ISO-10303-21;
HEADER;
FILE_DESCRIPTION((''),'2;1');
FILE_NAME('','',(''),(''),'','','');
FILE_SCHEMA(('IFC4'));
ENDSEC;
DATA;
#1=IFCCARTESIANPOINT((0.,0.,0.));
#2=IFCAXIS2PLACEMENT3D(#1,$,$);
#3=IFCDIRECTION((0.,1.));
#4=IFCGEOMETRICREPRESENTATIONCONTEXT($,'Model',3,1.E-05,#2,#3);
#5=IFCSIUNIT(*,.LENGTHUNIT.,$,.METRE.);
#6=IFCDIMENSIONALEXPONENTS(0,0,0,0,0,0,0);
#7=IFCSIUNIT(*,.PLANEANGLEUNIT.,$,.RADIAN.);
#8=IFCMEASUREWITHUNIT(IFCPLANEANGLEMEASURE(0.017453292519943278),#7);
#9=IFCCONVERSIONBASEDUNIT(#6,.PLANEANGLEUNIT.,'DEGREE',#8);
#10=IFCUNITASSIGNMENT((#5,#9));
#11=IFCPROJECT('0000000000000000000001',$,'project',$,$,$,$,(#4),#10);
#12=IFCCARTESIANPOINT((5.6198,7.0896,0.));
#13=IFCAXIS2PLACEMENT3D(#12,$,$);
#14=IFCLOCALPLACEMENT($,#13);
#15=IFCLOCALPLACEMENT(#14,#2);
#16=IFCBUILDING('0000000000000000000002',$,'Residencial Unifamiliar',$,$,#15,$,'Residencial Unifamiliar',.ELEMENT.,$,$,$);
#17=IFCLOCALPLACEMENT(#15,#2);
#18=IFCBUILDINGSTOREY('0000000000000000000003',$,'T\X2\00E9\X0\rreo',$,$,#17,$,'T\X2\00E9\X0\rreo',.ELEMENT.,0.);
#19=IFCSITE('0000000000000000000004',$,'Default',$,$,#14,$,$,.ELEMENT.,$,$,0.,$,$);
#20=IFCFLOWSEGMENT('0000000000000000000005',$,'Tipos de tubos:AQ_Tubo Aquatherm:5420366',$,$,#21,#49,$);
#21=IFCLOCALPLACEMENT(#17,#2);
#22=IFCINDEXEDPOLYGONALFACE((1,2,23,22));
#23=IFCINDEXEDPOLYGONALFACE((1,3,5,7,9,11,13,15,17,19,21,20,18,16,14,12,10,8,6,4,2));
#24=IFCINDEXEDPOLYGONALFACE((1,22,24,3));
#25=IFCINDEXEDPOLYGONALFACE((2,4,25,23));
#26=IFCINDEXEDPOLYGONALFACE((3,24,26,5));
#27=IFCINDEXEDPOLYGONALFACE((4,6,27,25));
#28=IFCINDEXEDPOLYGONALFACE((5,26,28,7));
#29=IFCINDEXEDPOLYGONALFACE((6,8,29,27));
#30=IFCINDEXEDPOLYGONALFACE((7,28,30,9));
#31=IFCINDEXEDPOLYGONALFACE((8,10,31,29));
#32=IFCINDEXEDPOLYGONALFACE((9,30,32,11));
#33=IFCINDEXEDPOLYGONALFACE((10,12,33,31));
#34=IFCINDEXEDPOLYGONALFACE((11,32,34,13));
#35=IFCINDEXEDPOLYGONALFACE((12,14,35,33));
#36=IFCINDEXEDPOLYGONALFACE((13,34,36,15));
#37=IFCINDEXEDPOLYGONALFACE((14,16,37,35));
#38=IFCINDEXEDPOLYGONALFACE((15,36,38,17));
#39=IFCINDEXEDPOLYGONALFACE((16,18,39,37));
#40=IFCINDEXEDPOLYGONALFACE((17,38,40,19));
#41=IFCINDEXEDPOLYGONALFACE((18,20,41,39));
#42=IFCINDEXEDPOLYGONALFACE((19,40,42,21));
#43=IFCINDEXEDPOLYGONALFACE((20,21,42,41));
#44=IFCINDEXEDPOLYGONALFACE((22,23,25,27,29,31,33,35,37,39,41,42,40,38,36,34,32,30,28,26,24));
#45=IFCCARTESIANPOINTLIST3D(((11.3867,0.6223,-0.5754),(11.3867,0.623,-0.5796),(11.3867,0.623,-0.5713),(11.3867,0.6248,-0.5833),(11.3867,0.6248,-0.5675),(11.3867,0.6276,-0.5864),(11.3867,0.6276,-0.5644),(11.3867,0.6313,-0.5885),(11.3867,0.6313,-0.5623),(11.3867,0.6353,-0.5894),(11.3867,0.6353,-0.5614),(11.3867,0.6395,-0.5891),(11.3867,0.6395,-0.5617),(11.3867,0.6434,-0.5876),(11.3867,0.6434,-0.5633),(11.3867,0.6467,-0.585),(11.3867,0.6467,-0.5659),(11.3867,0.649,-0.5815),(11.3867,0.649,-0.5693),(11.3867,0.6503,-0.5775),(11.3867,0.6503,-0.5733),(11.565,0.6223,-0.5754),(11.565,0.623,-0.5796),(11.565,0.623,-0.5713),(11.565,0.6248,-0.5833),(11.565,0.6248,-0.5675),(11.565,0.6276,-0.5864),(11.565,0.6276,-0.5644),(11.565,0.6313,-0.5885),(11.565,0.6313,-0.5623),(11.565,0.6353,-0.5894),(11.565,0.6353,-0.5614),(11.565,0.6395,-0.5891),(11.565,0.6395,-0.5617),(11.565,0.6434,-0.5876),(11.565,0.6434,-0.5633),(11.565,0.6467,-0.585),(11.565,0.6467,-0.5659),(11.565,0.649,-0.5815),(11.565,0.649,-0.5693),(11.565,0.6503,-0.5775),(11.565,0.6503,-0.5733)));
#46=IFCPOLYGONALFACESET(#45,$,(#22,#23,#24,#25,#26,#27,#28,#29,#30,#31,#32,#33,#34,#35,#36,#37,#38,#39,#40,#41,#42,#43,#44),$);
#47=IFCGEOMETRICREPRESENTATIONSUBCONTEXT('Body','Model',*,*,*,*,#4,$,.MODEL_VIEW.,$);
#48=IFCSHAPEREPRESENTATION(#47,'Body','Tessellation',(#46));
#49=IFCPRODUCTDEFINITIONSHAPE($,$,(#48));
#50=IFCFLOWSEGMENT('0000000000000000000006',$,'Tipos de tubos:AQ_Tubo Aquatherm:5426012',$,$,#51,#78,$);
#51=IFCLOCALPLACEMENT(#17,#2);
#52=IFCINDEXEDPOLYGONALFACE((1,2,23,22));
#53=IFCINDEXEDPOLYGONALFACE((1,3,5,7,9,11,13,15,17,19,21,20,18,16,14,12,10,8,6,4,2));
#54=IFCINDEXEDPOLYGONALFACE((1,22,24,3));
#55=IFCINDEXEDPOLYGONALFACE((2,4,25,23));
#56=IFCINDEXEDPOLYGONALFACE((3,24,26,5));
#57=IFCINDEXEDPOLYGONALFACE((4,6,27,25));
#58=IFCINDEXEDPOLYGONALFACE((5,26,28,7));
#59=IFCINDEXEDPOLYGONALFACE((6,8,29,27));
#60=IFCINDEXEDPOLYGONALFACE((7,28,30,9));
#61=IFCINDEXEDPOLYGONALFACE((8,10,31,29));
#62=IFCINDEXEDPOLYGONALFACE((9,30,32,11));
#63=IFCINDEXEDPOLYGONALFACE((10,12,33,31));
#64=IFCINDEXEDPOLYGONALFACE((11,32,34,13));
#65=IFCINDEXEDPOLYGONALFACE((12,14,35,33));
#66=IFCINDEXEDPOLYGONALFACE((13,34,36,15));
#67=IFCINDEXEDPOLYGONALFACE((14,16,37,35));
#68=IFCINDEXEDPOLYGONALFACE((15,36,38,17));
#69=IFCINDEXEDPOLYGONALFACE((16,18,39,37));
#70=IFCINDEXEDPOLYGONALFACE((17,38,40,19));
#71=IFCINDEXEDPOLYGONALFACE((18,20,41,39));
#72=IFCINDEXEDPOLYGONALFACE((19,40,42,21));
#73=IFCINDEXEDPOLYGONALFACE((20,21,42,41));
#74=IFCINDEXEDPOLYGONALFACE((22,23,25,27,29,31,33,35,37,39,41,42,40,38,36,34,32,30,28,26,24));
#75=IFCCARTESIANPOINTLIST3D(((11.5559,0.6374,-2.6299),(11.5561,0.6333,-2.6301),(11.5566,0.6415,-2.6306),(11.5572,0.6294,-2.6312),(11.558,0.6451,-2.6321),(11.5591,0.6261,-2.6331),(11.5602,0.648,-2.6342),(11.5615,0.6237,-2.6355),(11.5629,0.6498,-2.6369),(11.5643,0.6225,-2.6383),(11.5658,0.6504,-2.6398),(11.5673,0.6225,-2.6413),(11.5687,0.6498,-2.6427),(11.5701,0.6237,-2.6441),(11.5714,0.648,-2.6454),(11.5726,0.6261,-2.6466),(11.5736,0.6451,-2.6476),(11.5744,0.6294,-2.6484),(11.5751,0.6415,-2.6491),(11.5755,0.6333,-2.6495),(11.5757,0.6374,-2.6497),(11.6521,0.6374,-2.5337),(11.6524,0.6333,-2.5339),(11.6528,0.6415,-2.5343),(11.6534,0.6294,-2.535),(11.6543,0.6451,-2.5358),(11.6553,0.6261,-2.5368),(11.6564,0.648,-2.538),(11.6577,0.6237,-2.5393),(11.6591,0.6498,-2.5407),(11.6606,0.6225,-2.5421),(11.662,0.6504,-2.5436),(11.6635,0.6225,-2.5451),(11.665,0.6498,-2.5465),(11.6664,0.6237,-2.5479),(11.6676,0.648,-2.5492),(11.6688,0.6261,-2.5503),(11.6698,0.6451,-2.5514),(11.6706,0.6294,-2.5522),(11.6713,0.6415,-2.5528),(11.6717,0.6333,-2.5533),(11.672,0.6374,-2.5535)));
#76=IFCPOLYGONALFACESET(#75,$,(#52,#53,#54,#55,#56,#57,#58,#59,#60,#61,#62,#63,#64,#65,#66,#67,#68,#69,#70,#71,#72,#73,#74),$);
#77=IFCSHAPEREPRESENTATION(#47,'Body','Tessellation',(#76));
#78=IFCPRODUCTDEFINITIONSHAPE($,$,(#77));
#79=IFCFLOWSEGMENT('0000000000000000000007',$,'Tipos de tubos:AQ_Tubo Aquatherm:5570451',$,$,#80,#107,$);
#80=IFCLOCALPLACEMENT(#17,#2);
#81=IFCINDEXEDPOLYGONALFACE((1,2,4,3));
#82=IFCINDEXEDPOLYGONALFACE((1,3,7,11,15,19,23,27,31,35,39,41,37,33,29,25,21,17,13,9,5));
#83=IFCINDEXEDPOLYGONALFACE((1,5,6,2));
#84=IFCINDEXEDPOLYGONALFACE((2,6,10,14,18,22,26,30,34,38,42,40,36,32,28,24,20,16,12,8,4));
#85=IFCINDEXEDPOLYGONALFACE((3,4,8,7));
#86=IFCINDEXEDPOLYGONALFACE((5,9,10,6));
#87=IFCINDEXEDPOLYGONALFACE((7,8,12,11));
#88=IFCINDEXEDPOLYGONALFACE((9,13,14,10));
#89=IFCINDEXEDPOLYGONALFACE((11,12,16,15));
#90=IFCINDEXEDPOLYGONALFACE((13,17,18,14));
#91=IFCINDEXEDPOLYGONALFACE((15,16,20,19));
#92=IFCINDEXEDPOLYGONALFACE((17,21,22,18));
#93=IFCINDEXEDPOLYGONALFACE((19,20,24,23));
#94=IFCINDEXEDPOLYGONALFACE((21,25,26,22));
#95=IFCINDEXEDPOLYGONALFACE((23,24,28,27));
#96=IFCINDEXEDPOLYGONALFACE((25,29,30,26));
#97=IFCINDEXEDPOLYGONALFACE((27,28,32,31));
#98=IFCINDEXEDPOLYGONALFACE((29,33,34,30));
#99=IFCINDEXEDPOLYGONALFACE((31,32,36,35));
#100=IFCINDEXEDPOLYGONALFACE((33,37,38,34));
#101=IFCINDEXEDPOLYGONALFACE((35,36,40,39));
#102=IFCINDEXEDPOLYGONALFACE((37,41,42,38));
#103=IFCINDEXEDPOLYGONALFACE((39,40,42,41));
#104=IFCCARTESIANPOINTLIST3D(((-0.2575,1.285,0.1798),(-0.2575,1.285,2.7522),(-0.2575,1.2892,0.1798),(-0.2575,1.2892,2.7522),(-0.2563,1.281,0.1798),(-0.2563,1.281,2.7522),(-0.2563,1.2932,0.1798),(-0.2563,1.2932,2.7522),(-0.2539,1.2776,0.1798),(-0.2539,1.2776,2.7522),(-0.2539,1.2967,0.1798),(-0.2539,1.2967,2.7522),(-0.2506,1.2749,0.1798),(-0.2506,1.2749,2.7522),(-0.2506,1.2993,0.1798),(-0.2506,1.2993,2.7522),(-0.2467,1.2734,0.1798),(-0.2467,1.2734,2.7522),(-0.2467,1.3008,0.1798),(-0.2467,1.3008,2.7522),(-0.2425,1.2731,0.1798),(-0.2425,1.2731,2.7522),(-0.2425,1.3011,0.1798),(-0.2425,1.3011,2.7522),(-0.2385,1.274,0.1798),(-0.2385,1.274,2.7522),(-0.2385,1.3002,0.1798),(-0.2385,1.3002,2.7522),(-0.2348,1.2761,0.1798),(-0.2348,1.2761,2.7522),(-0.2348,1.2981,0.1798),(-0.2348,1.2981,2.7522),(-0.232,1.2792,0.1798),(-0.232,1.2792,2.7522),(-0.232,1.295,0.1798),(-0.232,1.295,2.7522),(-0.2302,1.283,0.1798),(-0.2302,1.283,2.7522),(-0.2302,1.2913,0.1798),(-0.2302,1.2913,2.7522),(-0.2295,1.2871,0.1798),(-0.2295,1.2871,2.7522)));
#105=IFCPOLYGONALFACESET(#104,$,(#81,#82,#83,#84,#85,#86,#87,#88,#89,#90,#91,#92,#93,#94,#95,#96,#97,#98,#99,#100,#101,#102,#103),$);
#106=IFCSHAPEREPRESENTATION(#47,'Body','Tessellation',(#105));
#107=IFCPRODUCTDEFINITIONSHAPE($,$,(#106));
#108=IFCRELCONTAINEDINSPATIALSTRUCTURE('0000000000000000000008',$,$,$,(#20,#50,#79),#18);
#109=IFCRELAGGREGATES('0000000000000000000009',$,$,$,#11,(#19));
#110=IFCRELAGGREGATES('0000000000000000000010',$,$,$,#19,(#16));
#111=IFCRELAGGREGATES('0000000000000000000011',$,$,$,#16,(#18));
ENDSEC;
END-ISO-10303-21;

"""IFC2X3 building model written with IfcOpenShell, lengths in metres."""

from ifc_helpers import new_model, entity, si_unit, converted_unit, direction, frame, frame_2d, origin, origin_2d_with_axis, place, context, subcontext, project, spatial, circle, extrude, element, save


model = new_model("IFC2X3")

# Units and contexts
model_context = context("Model", 3, precision=1e-05, world=origin(), true_north=direction((0.0, 1.0)))
body_context = subcontext(model_context, "Body", "Model", "MODEL_VIEW")
ifc_project = project(units=[si_unit("LENGTHUNIT", "METRE"), converted_unit("PLANEANGLEUNIT", "DEGREE", entity("IfcPlaneAngleMeasure", 0.017453292519943278), si_unit("PLANEANGLEUNIT", "RADIAN"), dimensions=[0, 0, 0, 0, 0, 0, 0])], contexts=[model_context])

# Site, building, storey
site_placement = place(None, frame((5.6198, 7.0896, 0.0)))
site = spatial("IfcSite", under=ifc_project, at=site_placement, Name="Default", CompositionType="ELEMENT", RefElevation=0.0)
building_placement = place(site_placement, origin())
building = spatial("IfcBuilding", under=site, at=building_placement, Name="Residencial Unifamiliar", LongName="Residencial Unifamiliar", CompositionType="ELEMENT")
storey_placement = place(building_placement, origin())
storey = spatial("IfcBuildingStorey", under=building, at=storey_placement, Name="Térreo", LongName="Térreo", CompositionType="ELEMENT", Elevation=0.0)

# Flow segments
flow_segment_1_placement = place(storey_placement, origin())
element("IfcFlowSegment", 1, at=flow_segment_1_placement, inside=storey, Name="Tipos de tubos:AQ_Tubo Aquatherm:5420366", context=body_context, shape_type="SweptSolid", body=[
    extrude(circle(Radius=0.0141, at=origin_2d_with_axis()), frame((11.3867, 0.6364, -0.5754), z_axis=(1.0, 0.0, 0.0), x_axis=(0.0, -1.0, 0.0)), (0.0, 0.0, 1.0), 0.1783),
])
flow_segment_2_placement = place(storey_placement, origin())
element("IfcFlowSegment", 2, at=flow_segment_2_placement, inside=storey, Name="Tipos de tubos:AQ_Tubo Aquatherm:5426012", context=body_context, shape_type="SweptSolid", body=[
    extrude(circle(Radius=0.0141, at=frame_2d((0.0, 0.0), x_axis=(1.0, 0.0))), frame((11.5658, 0.6364, -2.6398), z_axis=(0.707107, 0.0, 0.707107), x_axis=(0.0, 1.0, 0.0)), (0.0, 0.0, 1.0), 0.1361),
])
flow_segment_3_placement = place(storey_placement, origin())
element("IfcFlowSegment", 3, at=flow_segment_3_placement, inside=storey, Name="Tipos de tubos:AQ_Tubo Aquatherm:5570451", context=body_context, shape_type="SweptSolid", body=[
    extrude(circle(Radius=0.0141, at=origin_2d_with_axis()), frame((-0.2436, 1.2871, 0.1798)), (0.0, 0.0, 1.0), 2.5724),
])

save(model, "model.ifc")
